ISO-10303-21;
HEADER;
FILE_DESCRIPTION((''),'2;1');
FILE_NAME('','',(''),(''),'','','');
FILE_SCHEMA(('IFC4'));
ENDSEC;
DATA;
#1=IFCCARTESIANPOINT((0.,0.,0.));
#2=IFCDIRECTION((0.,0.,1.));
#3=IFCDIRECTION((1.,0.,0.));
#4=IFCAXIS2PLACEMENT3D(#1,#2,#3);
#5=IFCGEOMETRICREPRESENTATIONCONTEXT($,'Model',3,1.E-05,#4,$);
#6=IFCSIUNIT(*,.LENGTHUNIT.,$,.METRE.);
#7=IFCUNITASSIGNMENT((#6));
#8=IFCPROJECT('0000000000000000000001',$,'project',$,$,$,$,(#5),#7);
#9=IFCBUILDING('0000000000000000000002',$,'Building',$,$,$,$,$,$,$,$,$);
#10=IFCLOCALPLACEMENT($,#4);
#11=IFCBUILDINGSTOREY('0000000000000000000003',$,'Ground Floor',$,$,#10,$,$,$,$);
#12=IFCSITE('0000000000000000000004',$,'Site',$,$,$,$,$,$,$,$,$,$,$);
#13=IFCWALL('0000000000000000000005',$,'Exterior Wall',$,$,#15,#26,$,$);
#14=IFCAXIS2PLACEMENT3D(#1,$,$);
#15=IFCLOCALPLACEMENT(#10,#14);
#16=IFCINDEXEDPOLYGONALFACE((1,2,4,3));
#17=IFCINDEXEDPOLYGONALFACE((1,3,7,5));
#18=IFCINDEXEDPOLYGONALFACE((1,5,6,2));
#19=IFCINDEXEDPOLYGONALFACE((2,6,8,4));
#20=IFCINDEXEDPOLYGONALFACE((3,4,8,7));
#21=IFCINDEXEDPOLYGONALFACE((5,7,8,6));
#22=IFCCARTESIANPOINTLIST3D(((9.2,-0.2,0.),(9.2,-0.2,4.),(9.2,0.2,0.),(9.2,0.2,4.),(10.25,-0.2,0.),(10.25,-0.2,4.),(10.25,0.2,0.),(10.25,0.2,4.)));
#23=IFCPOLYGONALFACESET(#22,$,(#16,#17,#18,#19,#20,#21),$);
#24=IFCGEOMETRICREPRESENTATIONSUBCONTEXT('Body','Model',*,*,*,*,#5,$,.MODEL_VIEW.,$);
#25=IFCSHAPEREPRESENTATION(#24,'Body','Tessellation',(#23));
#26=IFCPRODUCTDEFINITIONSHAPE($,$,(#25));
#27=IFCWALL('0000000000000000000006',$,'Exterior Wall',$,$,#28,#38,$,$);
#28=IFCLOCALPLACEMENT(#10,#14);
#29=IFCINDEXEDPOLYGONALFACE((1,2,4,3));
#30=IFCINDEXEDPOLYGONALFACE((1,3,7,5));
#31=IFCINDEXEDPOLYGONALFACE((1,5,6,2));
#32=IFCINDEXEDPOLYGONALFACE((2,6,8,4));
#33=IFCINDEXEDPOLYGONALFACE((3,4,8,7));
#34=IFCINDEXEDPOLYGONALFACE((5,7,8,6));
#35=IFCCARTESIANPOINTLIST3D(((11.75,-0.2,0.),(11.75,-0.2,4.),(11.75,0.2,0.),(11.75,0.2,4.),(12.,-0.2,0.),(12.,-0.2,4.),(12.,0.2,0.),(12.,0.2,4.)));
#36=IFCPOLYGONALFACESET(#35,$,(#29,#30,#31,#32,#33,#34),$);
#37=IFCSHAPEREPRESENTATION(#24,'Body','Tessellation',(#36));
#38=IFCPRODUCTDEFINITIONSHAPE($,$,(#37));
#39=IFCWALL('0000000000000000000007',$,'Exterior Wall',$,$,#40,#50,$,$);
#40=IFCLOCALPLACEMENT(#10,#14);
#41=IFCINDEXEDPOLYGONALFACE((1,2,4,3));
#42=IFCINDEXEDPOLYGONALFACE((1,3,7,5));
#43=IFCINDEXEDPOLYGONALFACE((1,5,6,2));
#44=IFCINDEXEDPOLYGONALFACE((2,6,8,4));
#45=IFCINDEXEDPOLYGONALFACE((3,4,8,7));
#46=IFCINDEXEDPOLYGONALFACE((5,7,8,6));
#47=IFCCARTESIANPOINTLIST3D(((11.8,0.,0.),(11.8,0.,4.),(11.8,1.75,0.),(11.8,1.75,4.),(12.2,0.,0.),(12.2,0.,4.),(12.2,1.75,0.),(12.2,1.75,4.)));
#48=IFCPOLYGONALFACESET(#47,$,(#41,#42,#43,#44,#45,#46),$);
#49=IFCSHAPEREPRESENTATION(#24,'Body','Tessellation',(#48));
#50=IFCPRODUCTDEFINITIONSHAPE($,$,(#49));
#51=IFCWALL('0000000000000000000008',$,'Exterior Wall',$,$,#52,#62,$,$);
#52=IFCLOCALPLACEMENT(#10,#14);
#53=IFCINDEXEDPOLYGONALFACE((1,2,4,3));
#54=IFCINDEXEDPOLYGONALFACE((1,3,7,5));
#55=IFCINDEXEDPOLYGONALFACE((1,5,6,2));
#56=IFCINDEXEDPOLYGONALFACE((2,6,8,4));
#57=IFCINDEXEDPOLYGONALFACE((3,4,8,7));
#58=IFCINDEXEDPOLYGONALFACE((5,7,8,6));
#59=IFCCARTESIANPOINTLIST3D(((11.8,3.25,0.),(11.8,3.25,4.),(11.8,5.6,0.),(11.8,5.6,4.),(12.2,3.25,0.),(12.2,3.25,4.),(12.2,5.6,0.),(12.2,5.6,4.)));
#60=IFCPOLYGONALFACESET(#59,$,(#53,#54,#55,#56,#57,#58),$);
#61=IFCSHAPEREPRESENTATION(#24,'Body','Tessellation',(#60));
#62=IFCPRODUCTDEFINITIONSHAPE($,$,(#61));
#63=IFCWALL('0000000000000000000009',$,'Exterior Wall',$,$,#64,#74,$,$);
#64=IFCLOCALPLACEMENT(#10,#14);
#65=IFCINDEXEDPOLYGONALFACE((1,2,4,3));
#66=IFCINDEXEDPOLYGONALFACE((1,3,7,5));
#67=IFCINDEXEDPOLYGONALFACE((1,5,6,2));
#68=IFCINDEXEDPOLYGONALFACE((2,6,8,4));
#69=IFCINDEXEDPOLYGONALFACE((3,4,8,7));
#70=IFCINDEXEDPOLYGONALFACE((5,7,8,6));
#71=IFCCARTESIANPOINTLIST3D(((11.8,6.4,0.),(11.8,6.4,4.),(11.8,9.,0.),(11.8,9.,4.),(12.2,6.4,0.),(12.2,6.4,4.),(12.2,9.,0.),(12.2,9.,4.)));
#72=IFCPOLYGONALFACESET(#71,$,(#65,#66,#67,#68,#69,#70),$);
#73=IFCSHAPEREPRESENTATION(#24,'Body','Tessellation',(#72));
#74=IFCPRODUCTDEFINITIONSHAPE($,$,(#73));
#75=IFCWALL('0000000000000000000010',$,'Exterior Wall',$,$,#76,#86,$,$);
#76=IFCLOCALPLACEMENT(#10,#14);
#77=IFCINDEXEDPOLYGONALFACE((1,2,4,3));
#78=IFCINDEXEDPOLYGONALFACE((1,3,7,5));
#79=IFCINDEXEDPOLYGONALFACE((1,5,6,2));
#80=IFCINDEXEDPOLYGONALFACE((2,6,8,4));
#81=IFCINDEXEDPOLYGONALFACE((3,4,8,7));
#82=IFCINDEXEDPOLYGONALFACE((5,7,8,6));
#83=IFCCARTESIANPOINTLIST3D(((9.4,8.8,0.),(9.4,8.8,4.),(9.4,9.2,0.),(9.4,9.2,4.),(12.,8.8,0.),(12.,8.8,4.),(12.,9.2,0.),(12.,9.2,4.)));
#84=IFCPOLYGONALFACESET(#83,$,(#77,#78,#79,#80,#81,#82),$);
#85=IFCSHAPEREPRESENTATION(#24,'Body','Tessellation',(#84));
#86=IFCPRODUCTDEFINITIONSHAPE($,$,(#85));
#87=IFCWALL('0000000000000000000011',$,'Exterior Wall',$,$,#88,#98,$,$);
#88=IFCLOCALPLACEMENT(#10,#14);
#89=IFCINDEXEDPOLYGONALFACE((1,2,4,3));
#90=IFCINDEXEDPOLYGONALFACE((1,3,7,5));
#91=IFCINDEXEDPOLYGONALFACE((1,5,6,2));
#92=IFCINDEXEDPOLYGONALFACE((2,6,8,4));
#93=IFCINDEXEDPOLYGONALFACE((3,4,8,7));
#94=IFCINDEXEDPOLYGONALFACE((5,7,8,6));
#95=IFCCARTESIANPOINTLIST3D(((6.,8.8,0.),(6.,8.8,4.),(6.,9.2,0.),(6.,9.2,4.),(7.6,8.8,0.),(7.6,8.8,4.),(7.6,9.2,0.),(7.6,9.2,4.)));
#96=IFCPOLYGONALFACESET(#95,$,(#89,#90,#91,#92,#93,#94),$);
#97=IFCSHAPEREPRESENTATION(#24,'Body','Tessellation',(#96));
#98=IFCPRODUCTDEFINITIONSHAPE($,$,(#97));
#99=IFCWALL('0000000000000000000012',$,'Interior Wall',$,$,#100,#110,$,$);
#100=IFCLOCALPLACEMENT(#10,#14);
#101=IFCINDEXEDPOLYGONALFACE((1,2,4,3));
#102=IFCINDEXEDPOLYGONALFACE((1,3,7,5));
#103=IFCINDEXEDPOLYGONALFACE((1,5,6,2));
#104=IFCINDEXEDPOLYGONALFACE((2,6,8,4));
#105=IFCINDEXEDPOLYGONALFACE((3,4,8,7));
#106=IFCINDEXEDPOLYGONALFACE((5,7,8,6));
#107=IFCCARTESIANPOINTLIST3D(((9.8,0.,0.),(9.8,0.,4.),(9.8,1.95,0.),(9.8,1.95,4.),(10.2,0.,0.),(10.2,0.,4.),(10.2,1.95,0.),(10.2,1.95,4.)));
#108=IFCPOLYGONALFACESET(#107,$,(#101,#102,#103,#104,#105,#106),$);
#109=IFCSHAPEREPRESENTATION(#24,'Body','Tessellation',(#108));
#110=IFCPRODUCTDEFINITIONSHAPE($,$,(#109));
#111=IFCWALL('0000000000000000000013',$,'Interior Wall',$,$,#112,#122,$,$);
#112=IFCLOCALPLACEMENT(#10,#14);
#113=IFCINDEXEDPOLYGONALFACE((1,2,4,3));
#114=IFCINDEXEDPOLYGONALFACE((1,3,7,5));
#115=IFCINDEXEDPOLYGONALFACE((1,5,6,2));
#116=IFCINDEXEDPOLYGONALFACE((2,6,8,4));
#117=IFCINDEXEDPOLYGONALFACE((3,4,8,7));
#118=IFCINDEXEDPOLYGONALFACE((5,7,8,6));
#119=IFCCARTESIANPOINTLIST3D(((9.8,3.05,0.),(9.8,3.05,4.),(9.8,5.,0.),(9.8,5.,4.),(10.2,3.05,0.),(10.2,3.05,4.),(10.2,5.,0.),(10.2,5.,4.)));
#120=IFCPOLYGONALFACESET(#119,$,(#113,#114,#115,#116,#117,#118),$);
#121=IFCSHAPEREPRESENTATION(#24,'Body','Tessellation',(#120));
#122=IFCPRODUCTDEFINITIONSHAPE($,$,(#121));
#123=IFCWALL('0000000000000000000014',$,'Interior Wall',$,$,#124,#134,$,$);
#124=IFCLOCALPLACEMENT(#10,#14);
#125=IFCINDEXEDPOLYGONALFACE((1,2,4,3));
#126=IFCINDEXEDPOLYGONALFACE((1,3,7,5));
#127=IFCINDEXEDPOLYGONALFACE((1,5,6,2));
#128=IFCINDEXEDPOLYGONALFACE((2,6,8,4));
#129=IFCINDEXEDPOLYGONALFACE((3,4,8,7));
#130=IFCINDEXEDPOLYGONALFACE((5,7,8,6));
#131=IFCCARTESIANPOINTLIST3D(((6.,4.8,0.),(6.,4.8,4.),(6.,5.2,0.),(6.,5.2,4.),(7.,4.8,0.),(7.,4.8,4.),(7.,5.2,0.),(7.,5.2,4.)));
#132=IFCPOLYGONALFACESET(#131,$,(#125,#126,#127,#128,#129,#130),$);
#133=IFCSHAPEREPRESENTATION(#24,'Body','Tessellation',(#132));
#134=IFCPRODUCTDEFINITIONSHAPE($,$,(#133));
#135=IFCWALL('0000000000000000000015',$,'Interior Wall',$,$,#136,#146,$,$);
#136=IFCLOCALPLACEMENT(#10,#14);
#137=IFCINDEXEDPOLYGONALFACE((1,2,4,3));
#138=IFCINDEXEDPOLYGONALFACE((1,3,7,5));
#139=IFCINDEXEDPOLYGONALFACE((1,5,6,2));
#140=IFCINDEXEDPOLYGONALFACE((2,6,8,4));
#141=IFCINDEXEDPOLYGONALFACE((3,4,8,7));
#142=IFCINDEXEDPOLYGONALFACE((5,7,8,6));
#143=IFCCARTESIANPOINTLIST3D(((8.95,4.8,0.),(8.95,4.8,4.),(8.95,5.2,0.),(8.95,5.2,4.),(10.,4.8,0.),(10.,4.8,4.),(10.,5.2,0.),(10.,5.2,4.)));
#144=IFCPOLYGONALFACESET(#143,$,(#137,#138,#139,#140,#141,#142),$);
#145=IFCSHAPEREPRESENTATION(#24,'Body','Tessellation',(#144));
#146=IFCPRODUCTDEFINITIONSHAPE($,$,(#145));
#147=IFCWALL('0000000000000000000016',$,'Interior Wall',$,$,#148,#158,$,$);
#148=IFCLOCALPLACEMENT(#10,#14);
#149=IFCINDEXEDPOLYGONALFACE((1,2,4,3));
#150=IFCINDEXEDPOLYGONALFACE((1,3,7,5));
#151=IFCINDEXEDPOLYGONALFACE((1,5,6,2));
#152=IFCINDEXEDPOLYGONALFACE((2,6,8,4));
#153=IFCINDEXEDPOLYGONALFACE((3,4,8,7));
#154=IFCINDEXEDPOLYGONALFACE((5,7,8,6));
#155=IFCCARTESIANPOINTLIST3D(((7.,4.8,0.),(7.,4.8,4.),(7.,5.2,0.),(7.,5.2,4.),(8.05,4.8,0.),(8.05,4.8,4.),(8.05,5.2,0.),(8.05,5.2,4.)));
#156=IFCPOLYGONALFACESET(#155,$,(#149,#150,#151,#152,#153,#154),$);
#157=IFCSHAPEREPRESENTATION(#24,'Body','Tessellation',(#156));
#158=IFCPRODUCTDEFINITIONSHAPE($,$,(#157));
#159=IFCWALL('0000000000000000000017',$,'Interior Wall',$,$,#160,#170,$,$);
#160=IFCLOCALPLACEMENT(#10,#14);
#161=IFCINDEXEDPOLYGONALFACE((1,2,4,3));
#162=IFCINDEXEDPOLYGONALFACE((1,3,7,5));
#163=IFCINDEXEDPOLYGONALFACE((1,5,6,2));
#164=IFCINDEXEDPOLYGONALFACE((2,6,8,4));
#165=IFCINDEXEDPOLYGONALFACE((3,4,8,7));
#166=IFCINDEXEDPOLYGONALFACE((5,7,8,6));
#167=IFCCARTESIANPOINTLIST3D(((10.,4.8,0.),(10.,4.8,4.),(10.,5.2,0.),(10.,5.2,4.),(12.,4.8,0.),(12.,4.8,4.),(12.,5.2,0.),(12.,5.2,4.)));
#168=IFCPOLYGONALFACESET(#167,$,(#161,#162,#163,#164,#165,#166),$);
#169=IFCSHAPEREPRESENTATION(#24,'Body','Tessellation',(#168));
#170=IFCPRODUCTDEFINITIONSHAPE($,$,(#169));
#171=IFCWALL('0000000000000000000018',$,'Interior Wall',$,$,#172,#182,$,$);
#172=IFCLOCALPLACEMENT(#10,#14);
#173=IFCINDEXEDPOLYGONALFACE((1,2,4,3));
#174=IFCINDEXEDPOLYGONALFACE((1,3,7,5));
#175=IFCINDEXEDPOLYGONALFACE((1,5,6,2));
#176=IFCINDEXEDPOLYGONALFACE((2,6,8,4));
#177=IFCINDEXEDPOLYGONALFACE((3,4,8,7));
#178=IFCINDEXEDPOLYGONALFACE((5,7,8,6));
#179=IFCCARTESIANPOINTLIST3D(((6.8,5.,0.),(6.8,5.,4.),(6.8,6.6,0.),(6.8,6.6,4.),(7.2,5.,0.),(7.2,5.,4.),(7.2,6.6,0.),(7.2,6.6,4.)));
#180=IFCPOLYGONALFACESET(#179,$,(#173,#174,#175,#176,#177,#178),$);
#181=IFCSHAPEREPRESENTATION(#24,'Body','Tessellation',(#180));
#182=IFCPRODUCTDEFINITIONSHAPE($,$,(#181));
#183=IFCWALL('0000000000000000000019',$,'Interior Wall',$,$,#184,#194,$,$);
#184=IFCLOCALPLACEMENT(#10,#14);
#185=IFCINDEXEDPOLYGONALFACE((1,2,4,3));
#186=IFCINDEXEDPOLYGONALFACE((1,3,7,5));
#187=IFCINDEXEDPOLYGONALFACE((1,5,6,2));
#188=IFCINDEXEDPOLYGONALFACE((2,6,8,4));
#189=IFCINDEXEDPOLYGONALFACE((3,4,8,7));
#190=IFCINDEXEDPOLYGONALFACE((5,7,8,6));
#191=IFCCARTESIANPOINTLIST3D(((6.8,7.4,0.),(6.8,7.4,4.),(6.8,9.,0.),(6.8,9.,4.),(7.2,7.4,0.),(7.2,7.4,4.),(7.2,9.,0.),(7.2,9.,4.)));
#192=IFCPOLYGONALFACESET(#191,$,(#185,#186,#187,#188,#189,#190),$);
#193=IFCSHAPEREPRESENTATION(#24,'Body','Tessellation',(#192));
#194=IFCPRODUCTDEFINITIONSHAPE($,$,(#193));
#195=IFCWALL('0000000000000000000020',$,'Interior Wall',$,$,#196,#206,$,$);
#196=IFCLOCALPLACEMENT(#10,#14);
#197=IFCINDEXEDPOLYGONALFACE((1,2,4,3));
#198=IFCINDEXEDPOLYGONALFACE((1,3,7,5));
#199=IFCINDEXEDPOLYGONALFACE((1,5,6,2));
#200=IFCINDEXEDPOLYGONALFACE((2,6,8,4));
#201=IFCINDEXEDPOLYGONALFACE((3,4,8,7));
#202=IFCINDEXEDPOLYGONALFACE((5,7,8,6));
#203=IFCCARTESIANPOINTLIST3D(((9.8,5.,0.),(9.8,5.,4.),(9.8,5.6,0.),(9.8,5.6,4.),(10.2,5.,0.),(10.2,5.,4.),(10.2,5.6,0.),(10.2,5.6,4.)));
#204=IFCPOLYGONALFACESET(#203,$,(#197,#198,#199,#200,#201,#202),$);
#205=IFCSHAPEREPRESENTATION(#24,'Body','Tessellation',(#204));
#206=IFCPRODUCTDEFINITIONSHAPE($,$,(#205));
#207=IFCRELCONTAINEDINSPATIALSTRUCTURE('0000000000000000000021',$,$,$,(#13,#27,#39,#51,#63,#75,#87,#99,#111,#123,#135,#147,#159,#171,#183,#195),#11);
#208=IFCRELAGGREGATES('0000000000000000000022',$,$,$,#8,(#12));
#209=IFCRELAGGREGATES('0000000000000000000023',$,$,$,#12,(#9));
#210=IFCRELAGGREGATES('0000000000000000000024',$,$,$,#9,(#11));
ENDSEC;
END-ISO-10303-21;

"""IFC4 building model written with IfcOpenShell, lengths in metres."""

from ifc_helpers import new_model, si_unit, frame, origin_with_axes, place, context, subcontext, project, spatial, indexed_curve, outline, extrude, element, save


model = new_model("IFC4")

# Units and contexts
model_context = context("Model", 3, precision=1e-05, world=origin_with_axes())
body_context = subcontext(model_context, "Body", "Model", "MODEL_VIEW")
ifc_project = project(units=[si_unit("LENGTHUNIT", "METRE")], contexts=[model_context])

# Site, building, storey
site = spatial("IfcSite", under=ifc_project, Name="Site")
building = spatial("IfcBuilding", under=site, Name="Building")
storey_placement = place(None, origin_with_axes())
storey = spatial("IfcBuildingStorey", under=building, at=storey_placement, Name="Ground Floor")

# Walls
wall_1_placement = place(storey_placement, frame((9.2, 0.0, 0.0), z_axis=(0.0, 0.0, 1.0), x_axis=(1.0, 0.0, 0.0)))
element("IfcWall", 1, at=wall_1_placement, inside=storey, Name="Exterior Wall", context=body_context, shape_type="SweptSolid", body=[
    extrude(outline(indexed_curve([(0.0, 0.0), (0.0, 0.4), (1.05, 0.4), (1.05, 0.0), (0.0, 0.0)], self_intersect=False)), frame((0.0, -0.2, 0.0), z_axis=(0.0, 0.0, 1.0), x_axis=(1.0, 0.0, 0.0)), (0.0, 0.0, 1.0), 4.0),
])
wall_2_placement = place(storey_placement, frame((11.75, 0.0, 0.0), z_axis=(0.0, 0.0, 1.0), x_axis=(1.0, 0.0, 0.0)))
element("IfcWall", 2, at=wall_2_placement, inside=storey, Name="Exterior Wall", context=body_context, shape_type="SweptSolid", body=[
    extrude(outline(indexed_curve([(0.0, 0.0), (0.0, 0.4), (0.25, 0.4), (0.25, 0.0), (0.0, 0.0)], self_intersect=False)), frame((0.0, -0.2, 0.0), z_axis=(0.0, 0.0, 1.0), x_axis=(1.0, 0.0, 0.0)), (0.0, 0.0, 1.0), 4.0),
])
wall_3_placement = place(storey_placement, frame((12.0, 0.0, 0.0), z_axis=(0.0, 0.0, 1.0), x_axis=(0.0, 1.0, 0.0)))
element("IfcWall", 3, at=wall_3_placement, inside=storey, Name="Exterior Wall", context=body_context, shape_type="SweptSolid", body=[
    extrude(outline(indexed_curve([(0.0, 0.0), (0.0, 0.4), (1.75, 0.4), (1.75, 0.0), (0.0, 0.0)], self_intersect=False)), frame((0.0, -0.2, 0.0), z_axis=(0.0, 0.0, 1.0), x_axis=(1.0, 0.0, 0.0)), (0.0, 0.0, 1.0), 4.0),
])
wall_4_placement = place(storey_placement, frame((12.0, 3.25, 0.0), z_axis=(0.0, 0.0, 1.0), x_axis=(0.0, 1.0, 0.0)))
element("IfcWall", 4, at=wall_4_placement, inside=storey, Name="Exterior Wall", context=body_context, shape_type="SweptSolid", body=[
    extrude(outline(indexed_curve([(0.0, 0.0), (0.0, 0.4), (2.35, 0.4), (2.35, 0.0), (0.0, 0.0)], self_intersect=False)), frame((0.0, -0.2, 0.0), z_axis=(0.0, 0.0, 1.0), x_axis=(1.0, 0.0, 0.0)), (0.0, 0.0, 1.0), 4.0),
])
for number, where, z_axis, x_axis, name in (
    (5, (12.0, 6.4, 0.0), (0.0, 0.0, 1.0), (0.0, 1.0, 0.0), "Exterior Wall"),
    (6, (12.0, 9.0, 0.0), (0.0, 0.0, 1.0), (-1.0, 0.0, 0.0), "Exterior Wall"),
):
    element("IfcWall", number, at=place(storey_placement, frame(where, z_axis=z_axis, x_axis=x_axis)), inside=storey, Name=name, context=body_context, shape_type="SweptSolid", body=[
        extrude(outline(indexed_curve([(0.0, 0.0), (0.0, 0.4), (2.6, 0.4), (2.6, 0.0), (0.0, 0.0)], self_intersect=False)), frame((0.0, -0.2, 0.0), z_axis=(0.0, 0.0, 1.0), x_axis=(1.0, 0.0, 0.0)), (0.0, 0.0, 1.0), 4.0),
    ])
wall_5_placement = place(storey_placement, frame((7.6, 9.0, 0.0), z_axis=(0.0, 0.0, 1.0), x_axis=(-1.0, 0.0, 0.0)))
element("IfcWall", 7, at=wall_5_placement, inside=storey, Name="Exterior Wall", context=body_context, shape_type="SweptSolid", body=[
    extrude(outline(indexed_curve([(0.0, 0.0), (0.0, 0.4), (1.6, 0.4), (1.6, 0.0), (0.0, 0.0)], self_intersect=False)), frame((0.0, -0.2, 0.0), z_axis=(0.0, 0.0, 1.0), x_axis=(1.0, 0.0, 0.0)), (0.0, 0.0, 1.0), 4.0),
])
wall_6_placement = place(storey_placement, frame((10.0, 0.0, 0.0), z_axis=(0.0, 0.0, 1.0), x_axis=(0.0, 1.0, 0.0)))
element("IfcWall", 8, at=wall_6_placement, inside=storey, Name="Interior Wall", context=body_context, shape_type="SweptSolid", body=[
    extrude(outline(indexed_curve([(0.0, 0.0), (0.0, 0.4), (1.95, 0.4), (1.95, 0.0), (0.0, 0.0)], self_intersect=False)), frame((0.0, -0.2, 0.0), z_axis=(0.0, 0.0, 1.0), x_axis=(1.0, 0.0, 0.0)), (0.0, 0.0, 1.0), 4.0),
])
wall_7_placement = place(storey_placement, frame((10.0, 3.05, 0.0), z_axis=(0.0, 0.0, 1.0), x_axis=(0.0, 1.0, 0.0)))
element("IfcWall", 9, at=wall_7_placement, inside=storey, Name="Interior Wall", context=body_context, shape_type="SweptSolid", body=[
    extrude(outline(indexed_curve([(0.0, 0.0), (0.0, 0.4), (1.95, 0.4), (1.95, 0.0), (0.0, 0.0)], self_intersect=False)), frame((0.0, -0.2, 0.0), z_axis=(0.0, 0.0, 1.0), x_axis=(1.0, 0.0, 0.0)), (0.0, 0.0, 1.0), 4.0),
])
wall_8_placement = place(storey_placement, frame((7.0, 5.0, 0.0), z_axis=(0.0, 0.0, 1.0), x_axis=(-1.0, 0.0, 0.0)))
element("IfcWall", 10, at=wall_8_placement, inside=storey, Name="Interior Wall", context=body_context, shape_type="SweptSolid", body=[
    extrude(outline(indexed_curve([(0.0, 0.0), (0.0, 0.4), (1.0, 0.4), (1.0, 0.0), (0.0, 0.0)], self_intersect=False)), frame((0.0, -0.2, 0.0), z_axis=(0.0, 0.0, 1.0), x_axis=(1.0, 0.0, 0.0)), (0.0, 0.0, 1.0), 4.0),
])
for number, where, z_axis, x_axis, name in (
    (11, (10.0, 5.0, 0.0), (0.0, 0.0, 1.0), (-1.0, 0.0, 0.0), "Interior Wall"),
    (12, (8.05, 5.0, 0.0), (0.0, 0.0, 1.0), (-1.0, 0.0, 0.0), "Interior Wall"),
):
    element("IfcWall", number, at=place(storey_placement, frame(where, z_axis=z_axis, x_axis=x_axis)), inside=storey, Name=name, context=body_context, shape_type="SweptSolid", body=[
        extrude(outline(indexed_curve([(0.0, 0.0), (0.0, 0.4), (1.05, 0.4), (1.05, 0.0), (0.0, 0.0)], self_intersect=False)), frame((0.0, -0.2, 0.0), z_axis=(0.0, 0.0, 1.0), x_axis=(1.0, 0.0, 0.0)), (0.0, 0.0, 1.0), 4.0),
    ])
wall_9_placement = place(storey_placement, frame((12.0, 5.0, 0.0), z_axis=(0.0, 0.0, 1.0), x_axis=(-1.0, 0.0, 0.0)))
element("IfcWall", 13, at=wall_9_placement, inside=storey, Name="Interior Wall", context=body_context, shape_type="SweptSolid", body=[
    extrude(outline(indexed_curve([(0.0, 0.0), (0.0, 0.4), (2.0, 0.4), (2.0, 0.0), (0.0, 0.0)], self_intersect=False)), frame((0.0, -0.2, 0.0), z_axis=(0.0, 0.0, 1.0), x_axis=(1.0, 0.0, 0.0)), (0.0, 0.0, 1.0), 4.0),
])
for number, where, z_axis, x_axis, name in (
    (14, (7.0, 5.0, 0.0), (0.0, 0.0, 1.0), (0.0, 1.0, 0.0), "Interior Wall"),
    (15, (7.0, 7.4, 0.0), (0.0, 0.0, 1.0), (0.0, 1.0, 0.0), "Interior Wall"),
):
    element("IfcWall", number, at=place(storey_placement, frame(where, z_axis=z_axis, x_axis=x_axis)), inside=storey, Name=name, context=body_context, shape_type="SweptSolid", body=[
        extrude(outline(indexed_curve([(0.0, 0.0), (0.0, 0.4), (1.6, 0.4), (1.6, 0.0), (0.0, 0.0)], self_intersect=False)), frame((0.0, -0.2, 0.0), z_axis=(0.0, 0.0, 1.0), x_axis=(1.0, 0.0, 0.0)), (0.0, 0.0, 1.0), 4.0),
    ])
for number, where, z_axis, x_axis, name in (
    (16, (10.0, 5.0, 0.0), (0.0, 0.0, 1.0), (0.0, 1.0, 0.0), "Interior Wall"),
):
    element("IfcWall", number, at=place(storey_placement, frame(where, z_axis=z_axis, x_axis=x_axis)), inside=storey, Name=name, context=body_context, shape_type="SweptSolid", body=[
        extrude(outline(indexed_curve([(0.0, 0.0), (0.0, 0.4), (0.6, 0.4), (0.6, 0.0), (0.0, 0.0)], self_intersect=False)), frame((0.0, -0.2, 0.0), z_axis=(0.0, 0.0, 1.0), x_axis=(1.0, 0.0, 0.0)), (0.0, 0.0, 1.0), 4.0),
    ])

save(model, "model.ifc")
